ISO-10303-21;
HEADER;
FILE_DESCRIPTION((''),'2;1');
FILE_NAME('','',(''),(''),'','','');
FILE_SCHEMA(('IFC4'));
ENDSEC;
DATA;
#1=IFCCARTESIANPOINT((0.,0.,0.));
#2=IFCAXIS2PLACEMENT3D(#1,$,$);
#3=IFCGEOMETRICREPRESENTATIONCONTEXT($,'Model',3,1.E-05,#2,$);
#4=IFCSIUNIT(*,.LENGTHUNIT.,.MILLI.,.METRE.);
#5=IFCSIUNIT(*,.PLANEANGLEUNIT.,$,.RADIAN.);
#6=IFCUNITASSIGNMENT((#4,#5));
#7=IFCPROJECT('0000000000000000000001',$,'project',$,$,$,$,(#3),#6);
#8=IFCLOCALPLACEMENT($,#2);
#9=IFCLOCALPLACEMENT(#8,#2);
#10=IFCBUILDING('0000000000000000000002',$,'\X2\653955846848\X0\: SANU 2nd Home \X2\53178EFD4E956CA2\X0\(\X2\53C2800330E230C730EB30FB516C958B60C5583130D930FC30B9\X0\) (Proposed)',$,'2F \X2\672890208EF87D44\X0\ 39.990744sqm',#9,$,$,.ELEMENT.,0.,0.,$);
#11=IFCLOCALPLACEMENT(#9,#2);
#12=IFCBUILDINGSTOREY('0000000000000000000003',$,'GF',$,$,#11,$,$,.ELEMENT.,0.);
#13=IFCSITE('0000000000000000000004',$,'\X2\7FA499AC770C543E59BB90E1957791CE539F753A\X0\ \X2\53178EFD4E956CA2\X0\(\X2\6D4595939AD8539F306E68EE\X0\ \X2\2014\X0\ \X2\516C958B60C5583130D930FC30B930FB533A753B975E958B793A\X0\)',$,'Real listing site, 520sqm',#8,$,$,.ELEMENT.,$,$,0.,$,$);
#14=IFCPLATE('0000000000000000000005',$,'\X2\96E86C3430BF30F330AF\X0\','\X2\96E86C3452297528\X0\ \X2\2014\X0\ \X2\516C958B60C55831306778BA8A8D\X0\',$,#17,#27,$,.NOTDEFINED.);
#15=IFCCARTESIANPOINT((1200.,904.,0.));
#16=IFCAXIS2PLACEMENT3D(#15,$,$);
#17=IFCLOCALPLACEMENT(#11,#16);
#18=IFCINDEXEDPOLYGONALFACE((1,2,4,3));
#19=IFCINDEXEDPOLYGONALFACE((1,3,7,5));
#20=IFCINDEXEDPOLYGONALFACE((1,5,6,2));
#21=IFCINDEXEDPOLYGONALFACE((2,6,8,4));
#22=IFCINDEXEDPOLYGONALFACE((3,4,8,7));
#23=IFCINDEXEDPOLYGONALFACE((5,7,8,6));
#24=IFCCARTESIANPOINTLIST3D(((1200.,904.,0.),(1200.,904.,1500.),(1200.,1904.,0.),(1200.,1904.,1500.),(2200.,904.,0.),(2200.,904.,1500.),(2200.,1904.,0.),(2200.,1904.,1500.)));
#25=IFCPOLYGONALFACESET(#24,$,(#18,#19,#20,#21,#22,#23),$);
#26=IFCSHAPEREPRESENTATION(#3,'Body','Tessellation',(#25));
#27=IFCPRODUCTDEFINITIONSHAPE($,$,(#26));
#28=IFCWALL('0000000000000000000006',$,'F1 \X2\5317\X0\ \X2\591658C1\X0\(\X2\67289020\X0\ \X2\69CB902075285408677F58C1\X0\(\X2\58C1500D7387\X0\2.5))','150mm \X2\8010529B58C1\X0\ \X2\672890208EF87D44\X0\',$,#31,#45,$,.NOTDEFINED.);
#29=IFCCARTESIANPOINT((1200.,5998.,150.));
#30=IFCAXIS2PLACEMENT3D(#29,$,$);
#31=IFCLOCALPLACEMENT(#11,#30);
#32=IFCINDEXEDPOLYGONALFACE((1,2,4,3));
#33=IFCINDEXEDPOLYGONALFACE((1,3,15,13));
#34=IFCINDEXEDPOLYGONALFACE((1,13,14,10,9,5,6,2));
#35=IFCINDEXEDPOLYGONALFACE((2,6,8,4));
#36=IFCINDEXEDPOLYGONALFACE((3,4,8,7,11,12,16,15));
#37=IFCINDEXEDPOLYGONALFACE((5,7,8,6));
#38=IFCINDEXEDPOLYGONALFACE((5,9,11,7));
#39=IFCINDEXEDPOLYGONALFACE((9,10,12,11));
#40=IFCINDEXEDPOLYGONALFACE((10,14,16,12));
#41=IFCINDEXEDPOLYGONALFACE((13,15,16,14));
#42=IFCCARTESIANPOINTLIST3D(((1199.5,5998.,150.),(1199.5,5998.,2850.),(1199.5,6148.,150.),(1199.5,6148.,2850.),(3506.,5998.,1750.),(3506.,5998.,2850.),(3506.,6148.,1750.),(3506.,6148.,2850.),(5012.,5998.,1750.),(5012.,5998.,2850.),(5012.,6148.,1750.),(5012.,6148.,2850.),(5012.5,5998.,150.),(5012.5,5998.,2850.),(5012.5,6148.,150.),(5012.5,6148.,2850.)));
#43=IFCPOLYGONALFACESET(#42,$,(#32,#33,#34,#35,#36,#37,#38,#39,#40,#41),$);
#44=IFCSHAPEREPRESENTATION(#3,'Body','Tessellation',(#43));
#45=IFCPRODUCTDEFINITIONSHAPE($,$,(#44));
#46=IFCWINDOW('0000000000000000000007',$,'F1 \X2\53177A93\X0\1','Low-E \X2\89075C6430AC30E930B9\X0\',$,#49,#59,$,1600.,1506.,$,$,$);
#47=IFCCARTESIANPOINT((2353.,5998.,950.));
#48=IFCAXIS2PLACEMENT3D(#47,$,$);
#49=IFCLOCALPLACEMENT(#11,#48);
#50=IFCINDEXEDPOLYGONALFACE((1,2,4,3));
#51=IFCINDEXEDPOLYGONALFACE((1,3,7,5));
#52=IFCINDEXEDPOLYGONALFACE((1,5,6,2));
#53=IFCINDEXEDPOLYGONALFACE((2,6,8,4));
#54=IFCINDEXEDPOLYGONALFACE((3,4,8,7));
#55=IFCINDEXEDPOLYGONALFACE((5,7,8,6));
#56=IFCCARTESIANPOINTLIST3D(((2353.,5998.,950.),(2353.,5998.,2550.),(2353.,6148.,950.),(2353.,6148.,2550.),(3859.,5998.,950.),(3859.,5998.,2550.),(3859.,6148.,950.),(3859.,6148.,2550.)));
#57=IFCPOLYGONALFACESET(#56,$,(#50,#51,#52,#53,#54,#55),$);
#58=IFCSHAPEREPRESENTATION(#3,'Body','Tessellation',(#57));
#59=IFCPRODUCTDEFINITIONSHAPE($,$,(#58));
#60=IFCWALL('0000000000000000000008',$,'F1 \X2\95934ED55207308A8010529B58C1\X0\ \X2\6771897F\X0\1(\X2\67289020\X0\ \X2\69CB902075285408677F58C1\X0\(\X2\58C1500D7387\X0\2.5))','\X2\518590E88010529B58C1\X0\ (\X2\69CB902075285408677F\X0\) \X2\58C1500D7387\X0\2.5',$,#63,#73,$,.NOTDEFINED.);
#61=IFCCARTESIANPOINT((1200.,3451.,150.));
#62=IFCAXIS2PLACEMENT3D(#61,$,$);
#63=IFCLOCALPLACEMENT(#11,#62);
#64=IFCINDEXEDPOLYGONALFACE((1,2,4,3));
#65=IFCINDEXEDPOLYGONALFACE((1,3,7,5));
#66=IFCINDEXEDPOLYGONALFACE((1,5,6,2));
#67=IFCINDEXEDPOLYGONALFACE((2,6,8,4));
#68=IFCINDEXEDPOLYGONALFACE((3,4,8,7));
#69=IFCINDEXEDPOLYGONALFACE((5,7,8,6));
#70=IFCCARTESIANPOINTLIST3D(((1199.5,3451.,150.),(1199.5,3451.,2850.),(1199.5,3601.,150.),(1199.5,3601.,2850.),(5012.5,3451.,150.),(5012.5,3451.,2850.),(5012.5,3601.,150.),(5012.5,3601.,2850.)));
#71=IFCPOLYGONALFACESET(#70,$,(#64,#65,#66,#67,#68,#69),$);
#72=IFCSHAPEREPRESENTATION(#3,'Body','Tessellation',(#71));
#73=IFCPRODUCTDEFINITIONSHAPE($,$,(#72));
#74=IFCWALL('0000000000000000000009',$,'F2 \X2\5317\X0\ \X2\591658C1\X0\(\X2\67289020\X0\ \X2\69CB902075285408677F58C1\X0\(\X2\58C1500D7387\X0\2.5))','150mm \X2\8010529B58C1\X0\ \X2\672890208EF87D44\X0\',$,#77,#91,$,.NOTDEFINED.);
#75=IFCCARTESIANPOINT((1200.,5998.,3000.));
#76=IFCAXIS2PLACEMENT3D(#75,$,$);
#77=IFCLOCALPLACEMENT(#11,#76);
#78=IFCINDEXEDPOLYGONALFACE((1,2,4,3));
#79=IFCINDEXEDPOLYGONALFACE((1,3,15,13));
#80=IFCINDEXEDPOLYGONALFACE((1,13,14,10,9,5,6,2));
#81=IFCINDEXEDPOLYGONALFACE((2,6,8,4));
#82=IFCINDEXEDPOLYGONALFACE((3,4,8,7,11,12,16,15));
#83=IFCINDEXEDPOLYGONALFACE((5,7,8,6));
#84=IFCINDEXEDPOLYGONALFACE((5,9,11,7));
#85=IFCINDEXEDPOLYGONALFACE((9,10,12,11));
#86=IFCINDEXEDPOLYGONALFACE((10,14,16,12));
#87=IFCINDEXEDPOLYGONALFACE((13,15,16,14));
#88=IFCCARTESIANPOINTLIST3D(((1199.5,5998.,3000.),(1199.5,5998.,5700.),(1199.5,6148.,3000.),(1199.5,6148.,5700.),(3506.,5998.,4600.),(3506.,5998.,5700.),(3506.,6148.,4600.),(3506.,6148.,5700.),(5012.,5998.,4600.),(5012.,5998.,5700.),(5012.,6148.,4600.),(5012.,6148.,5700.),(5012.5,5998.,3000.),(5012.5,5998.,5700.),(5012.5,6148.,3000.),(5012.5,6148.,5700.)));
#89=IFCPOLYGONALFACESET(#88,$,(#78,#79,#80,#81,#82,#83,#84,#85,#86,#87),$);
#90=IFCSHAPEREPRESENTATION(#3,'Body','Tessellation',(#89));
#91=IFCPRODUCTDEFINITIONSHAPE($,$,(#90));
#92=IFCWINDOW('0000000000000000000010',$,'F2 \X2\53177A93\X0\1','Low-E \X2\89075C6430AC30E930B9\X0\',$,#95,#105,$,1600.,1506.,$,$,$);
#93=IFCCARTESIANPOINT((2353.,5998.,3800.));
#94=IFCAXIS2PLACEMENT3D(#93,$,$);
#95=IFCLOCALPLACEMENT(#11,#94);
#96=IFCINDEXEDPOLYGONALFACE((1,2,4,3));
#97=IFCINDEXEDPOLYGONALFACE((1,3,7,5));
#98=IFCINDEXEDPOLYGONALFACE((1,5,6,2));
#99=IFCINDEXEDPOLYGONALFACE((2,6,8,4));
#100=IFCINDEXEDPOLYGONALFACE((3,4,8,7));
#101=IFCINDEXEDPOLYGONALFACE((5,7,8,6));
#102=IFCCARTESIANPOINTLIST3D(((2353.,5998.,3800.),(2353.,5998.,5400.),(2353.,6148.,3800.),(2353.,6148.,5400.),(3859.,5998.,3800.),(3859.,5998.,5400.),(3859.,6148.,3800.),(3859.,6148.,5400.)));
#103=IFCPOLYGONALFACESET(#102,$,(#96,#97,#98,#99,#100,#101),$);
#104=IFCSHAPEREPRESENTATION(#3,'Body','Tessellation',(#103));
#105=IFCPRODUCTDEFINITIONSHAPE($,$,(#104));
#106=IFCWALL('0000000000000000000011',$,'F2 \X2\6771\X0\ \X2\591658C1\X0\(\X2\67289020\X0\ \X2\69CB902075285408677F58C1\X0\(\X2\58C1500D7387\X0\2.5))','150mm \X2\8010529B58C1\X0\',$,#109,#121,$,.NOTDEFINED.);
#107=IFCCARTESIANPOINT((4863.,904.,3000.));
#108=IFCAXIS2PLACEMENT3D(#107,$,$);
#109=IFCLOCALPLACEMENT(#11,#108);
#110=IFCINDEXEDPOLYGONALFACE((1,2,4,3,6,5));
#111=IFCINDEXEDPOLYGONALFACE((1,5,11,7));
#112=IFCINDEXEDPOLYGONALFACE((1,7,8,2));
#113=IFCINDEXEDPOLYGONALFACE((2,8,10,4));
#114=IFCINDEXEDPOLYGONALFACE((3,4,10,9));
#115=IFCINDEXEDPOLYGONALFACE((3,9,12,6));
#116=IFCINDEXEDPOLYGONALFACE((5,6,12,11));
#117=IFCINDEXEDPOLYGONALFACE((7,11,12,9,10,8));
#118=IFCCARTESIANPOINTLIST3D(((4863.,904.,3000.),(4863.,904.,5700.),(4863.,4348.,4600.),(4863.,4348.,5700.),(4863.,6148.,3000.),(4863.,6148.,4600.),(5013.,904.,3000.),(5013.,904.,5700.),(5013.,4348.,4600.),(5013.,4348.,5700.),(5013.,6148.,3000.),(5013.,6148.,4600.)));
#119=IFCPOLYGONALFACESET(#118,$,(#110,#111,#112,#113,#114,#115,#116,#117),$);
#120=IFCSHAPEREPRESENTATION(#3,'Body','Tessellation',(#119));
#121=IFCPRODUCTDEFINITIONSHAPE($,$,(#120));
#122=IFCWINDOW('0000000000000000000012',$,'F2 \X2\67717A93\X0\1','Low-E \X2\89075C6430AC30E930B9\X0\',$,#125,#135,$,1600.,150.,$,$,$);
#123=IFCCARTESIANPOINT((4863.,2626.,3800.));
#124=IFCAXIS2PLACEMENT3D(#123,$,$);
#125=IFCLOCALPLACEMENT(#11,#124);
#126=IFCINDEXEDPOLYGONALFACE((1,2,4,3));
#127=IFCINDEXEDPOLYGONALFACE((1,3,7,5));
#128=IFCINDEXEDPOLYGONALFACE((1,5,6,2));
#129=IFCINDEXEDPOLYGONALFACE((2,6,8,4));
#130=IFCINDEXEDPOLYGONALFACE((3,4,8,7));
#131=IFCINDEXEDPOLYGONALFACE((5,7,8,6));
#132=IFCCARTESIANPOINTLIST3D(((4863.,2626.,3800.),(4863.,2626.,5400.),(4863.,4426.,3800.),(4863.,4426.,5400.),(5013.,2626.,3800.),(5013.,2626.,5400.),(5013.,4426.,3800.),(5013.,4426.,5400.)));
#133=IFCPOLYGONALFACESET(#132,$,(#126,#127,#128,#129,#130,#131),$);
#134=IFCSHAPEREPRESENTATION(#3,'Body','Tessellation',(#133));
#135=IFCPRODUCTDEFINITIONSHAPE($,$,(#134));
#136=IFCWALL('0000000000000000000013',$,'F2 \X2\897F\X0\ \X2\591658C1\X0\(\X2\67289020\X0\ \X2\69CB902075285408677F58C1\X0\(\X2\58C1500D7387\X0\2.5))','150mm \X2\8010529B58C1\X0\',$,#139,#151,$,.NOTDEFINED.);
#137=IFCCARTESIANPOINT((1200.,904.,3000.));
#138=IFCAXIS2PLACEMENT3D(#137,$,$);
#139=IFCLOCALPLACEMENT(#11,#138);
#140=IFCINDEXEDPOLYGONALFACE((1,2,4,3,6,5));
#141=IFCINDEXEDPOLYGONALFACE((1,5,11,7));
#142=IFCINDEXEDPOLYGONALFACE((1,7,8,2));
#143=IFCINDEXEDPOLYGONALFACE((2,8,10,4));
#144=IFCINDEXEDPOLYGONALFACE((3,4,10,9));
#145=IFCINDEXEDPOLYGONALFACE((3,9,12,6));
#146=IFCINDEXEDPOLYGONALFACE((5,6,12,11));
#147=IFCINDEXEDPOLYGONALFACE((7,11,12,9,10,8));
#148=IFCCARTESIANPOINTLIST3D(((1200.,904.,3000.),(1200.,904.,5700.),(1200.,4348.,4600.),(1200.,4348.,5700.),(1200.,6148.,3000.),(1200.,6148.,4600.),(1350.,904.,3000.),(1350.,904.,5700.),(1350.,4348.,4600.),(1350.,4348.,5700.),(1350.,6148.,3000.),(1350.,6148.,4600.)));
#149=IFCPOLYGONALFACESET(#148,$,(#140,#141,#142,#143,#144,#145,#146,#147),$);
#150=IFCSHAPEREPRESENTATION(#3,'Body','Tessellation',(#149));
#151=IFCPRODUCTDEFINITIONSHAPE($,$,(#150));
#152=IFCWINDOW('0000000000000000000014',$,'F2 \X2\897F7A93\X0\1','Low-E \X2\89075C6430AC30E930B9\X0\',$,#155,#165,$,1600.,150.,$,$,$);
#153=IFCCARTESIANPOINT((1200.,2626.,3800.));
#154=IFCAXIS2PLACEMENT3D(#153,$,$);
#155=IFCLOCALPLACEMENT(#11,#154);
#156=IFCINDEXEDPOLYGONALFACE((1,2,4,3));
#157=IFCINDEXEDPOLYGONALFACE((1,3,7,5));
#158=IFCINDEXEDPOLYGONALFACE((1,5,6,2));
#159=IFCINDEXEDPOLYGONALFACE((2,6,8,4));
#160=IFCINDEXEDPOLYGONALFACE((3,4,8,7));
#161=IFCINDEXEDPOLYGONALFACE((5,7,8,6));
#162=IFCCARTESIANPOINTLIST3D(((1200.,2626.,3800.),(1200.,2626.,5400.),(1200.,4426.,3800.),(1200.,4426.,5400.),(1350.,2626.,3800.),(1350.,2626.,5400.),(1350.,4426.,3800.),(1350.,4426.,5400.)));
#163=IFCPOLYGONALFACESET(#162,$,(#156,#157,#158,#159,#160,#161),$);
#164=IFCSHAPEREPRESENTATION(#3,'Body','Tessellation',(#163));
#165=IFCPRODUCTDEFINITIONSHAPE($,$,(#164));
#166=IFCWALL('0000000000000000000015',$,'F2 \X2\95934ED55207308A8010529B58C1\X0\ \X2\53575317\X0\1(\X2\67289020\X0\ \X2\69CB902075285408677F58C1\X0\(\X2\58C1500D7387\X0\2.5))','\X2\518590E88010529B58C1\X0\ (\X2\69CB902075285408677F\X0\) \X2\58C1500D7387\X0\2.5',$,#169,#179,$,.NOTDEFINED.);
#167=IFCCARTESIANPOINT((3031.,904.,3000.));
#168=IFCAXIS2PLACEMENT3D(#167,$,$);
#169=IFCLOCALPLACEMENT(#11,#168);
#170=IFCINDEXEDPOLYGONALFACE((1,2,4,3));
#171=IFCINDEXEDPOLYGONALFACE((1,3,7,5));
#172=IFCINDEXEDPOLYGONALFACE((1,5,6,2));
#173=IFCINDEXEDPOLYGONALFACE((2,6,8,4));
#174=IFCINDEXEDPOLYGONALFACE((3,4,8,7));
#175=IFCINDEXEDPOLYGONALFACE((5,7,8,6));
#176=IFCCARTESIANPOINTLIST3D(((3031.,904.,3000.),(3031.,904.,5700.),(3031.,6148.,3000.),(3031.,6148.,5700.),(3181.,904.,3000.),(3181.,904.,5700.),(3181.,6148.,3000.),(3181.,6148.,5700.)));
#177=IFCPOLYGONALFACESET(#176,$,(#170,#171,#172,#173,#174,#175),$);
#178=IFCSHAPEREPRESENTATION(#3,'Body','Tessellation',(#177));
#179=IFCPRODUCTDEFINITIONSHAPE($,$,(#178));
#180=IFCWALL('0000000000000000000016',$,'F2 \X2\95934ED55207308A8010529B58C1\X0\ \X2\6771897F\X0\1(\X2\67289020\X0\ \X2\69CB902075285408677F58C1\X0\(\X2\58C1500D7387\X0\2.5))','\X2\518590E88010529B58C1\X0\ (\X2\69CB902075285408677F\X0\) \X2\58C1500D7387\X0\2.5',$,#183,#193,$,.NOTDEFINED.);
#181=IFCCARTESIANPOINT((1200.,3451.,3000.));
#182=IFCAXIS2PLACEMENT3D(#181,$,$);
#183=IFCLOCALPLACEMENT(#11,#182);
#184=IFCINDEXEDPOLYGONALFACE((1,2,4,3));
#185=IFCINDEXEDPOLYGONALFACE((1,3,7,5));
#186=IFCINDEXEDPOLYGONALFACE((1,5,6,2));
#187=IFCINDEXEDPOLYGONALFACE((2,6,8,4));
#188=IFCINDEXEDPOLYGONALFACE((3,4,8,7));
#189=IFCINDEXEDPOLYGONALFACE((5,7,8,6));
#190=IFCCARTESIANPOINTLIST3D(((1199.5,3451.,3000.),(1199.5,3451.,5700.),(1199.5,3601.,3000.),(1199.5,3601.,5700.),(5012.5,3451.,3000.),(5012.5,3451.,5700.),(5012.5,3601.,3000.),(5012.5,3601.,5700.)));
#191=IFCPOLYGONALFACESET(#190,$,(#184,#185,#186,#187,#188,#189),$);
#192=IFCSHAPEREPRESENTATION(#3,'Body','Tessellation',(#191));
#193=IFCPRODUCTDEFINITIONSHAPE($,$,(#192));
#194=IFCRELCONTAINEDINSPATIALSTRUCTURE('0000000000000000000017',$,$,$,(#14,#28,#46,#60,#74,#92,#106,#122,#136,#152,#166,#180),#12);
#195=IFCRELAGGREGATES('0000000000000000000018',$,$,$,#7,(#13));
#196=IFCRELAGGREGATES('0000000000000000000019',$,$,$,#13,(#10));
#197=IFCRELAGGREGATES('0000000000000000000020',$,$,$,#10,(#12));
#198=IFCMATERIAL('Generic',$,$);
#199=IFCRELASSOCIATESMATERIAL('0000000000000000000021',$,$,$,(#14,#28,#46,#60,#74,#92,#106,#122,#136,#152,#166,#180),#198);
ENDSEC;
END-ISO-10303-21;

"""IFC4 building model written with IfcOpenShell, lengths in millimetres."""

from ifc_helpers import new_model, si_unit, frame, frame_2d, origin, place, context, project, spatial, rectangle, extrude, material, element, fill, save


model = new_model("IFC4")

# Units and contexts
model_context = context("Model", 3, precision=1e-05, world=origin())
ifc_project = project(units=[si_unit("LENGTHUNIT", "METRE", prefix="MILLI"), si_unit("PLANEANGLEUNIT", "RADIAN")], contexts=[model_context])

# Site, building, storey
site_placement = place(None, origin())
site = spatial("IfcSite", under=ifc_project, at=site_placement, Name="群馬県吾妻郡長野原町 北軽井沢(浅間高原の森 — 公開情報ベース・区画非開示)", ObjectType="Real listing site, 520sqm", CompositionType="ELEMENT", RefElevation=0.0)
building_placement = place(site_placement, origin())
building = spatial("IfcBuilding", under=site, at=building_placement, Name="改善案: SANU 2nd Home 北軽井沢(参考モデル・公開情報ベース) (Proposed)", ObjectType="2F 木造軸組 39.990744sqm", CompositionType="ELEMENT", ElevationOfRefHeight=0.0, ElevationOfTerrain=0.0)
storey_placement = place(building_placement, origin())
storey = spatial("IfcBuildingStorey", under=building, at=storey_placement, Name="GF", CompositionType="ELEMENT", Elevation=0.0)

# Plate
ifc_material_1 = material(Name="Generic")
plate_placement = place(storey_placement, frame((1200.0, 904.0, 0.0)))
element("IfcPlate", 1, at=plate_placement, inside=storey, material=ifc_material_1, Name="雨水タンク", Description="雨水利用 — 公開情報で確認", PredefinedType="NOTDEFINED", context=model_context, shape_type="SweptSolid", body=[
    extrude(rectangle(XDim=1000.0, YDim=1000.0, at=frame_2d((500.0, 500.0))), frame((1200.0, 904.0, 0.0)), (0.0, 0.0, 1.0), 1500.0),
])

# Wall, opening, window
wall_1_placement = place(storey_placement, frame((1200.0, 5998.0, 150.0)))
wall_1 = element("IfcWall", 2, at=wall_1_placement, inside=storey, material=ifc_material_1, Name="F1 北 外壁(木造 構造用合板壁(壁倍率2.5))", Description="150mm 耐力壁 木造軸組", PredefinedType="NOTDEFINED", context=model_context, shape_type="SweptSolid", body=[
    extrude(rectangle(XDim=3813.0, YDim=150.0, at=frame_2d((1906.0, 75.0))), frame((1200.0, 5998.0, 150.0)), (0.0, 0.0, 1.0), 2700.0),
])
opening_1_placement = place(storey_placement, frame((2353.0, 5998.0, 950.0)))
opening_1 = element("IfcOpeningElement", 3, at=opening_1_placement, cuts=wall_1, PredefinedType="NOTDEFINED", context=model_context, shape_type="SweptSolid", body=[
    extrude(rectangle(XDim=1506.0, YDim=150.0, at=frame_2d((753.0, 75.0))), frame((2353.0, 5998.0, 950.0)), (0.0, 0.0, 1.0), 1600.0),
])
window_1_placement = place(storey_placement, frame((2353.0, 5998.0, 950.0)))
window_1 = element("IfcWindow", 4, at=window_1_placement, inside=storey, material=ifc_material_1, Name="F1 北窓1", Description="Low-E 複層ガラス", OverallHeight=1600.0, OverallWidth=1506.0, context=model_context, shape_type="SweptSolid", body=[
    extrude(rectangle(XDim=1506.0, YDim=150.0, at=frame_2d((753.0, 75.0))), frame((2353.0, 5998.0, 950.0)), (0.0, 0.0, 1.0), 1600.0),
])
fill(opening_1, window_1)

# Wall
wall_2_placement = place(storey_placement, frame((1200.0, 3451.0, 150.0)))
element("IfcWall", 5, at=wall_2_placement, inside=storey, material=ifc_material_1, Name="F1 間仕切り耐力壁 東西1(木造 構造用合板壁(壁倍率2.5))", Description="内部耐力壁 (構造用合板) 壁倍率2.5", PredefinedType="NOTDEFINED", context=model_context, shape_type="SweptSolid", body=[
    extrude(rectangle(XDim=3813.0, YDim=150.0, at=frame_2d((1906.0, 75.0))), frame((1200.0, 3451.0, 150.0)), (0.0, 0.0, 1.0), 2700.0),
])

# Walls, openings, windows
wall_3_placement = place(storey_placement, frame((1200.0, 5998.0, 3000.0)))
wall_3 = element("IfcWall", 6, at=wall_3_placement, inside=storey, material=ifc_material_1, Name="F2 北 外壁(木造 構造用合板壁(壁倍率2.5))", Description="150mm 耐力壁 木造軸組", PredefinedType="NOTDEFINED", context=model_context, shape_type="SweptSolid", body=[
    extrude(rectangle(XDim=3813.0, YDim=150.0, at=frame_2d((1906.0, 75.0))), frame((1200.0, 5998.0, 3000.0)), (0.0, 0.0, 1.0), 2700.0),
])
opening_2_placement = place(storey_placement, frame((2353.0, 5998.0, 3800.0)))
opening_2 = element("IfcOpeningElement", 7, at=opening_2_placement, cuts=wall_3, PredefinedType="NOTDEFINED", context=model_context, shape_type="SweptSolid", body=[
    extrude(rectangle(XDim=1506.0, YDim=150.0, at=frame_2d((753.0, 75.0))), frame((2353.0, 5998.0, 3800.0)), (0.0, 0.0, 1.0), 1600.0),
])
window_2_placement = place(storey_placement, frame((2353.0, 5998.0, 3800.0)))
window_2 = element("IfcWindow", 8, at=window_2_placement, inside=storey, material=ifc_material_1, Name="F2 北窓1", Description="Low-E 複層ガラス", OverallHeight=1600.0, OverallWidth=1506.0, context=model_context, shape_type="SweptSolid", body=[
    extrude(rectangle(XDim=1506.0, YDim=150.0, at=frame_2d((753.0, 75.0))), frame((2353.0, 5998.0, 3800.0)), (0.0, 0.0, 1.0), 1600.0),
])
fill(opening_2, window_2)
wall_4_placement = place(storey_placement, frame((4863.0, 904.0, 3000.0)))
wall_4 = element("IfcWall", 9, at=wall_4_placement, inside=storey, material=ifc_material_1, Name="F2 東 外壁(木造 構造用合板壁(壁倍率2.5))", Description="150mm 耐力壁", PredefinedType="NOTDEFINED", context=model_context, shape_type="SweptSolid", body=[
    extrude(rectangle(XDim=150.0, YDim=5244.0, at=frame_2d((75.0, 2622.0))), frame((4863.0, 904.0, 3000.0)), (0.0, 0.0, 1.0), 2700.0),
])
opening_3_placement = place(storey_placement, frame((4863.0, 2626.0, 3800.0)))
opening_3 = element("IfcOpeningElement", 10, at=opening_3_placement, cuts=wall_4, PredefinedType="NOTDEFINED", context=model_context, shape_type="SweptSolid", body=[
    extrude(rectangle(XDim=150.0, YDim=1800.0, at=frame_2d((75.0, 900.0))), frame((4863.0, 2626.0, 3800.0)), (0.0, 0.0, 1.0), 1600.0),
])
window_3_placement = place(storey_placement, frame((4863.0, 2626.0, 3800.0)))
window_3 = element("IfcWindow", 11, at=window_3_placement, inside=storey, material=ifc_material_1, Name="F2 東窓1", Description="Low-E 複層ガラス", OverallHeight=1600.0, OverallWidth=150.0, context=model_context, shape_type="SweptSolid", body=[
    extrude(rectangle(XDim=150.0, YDim=1800.0, at=frame_2d((75.0, 900.0))), frame((4863.0, 2626.0, 3800.0)), (0.0, 0.0, 1.0), 1600.0),
])
fill(opening_3, window_3)
wall_5_placement = place(storey_placement, frame((1200.0, 904.0, 3000.0)))
wall_5 = element("IfcWall", 12, at=wall_5_placement, inside=storey, material=ifc_material_1, Name="F2 西 外壁(木造 構造用合板壁(壁倍率2.5))", Description="150mm 耐力壁", PredefinedType="NOTDEFINED", context=model_context, shape_type="SweptSolid", body=[
    extrude(rectangle(XDim=150.0, YDim=5244.0, at=frame_2d((75.0, 2622.0))), frame((1200.0, 904.0, 3000.0)), (0.0, 0.0, 1.0), 2700.0),
])
opening_4_placement = place(storey_placement, frame((1200.0, 2626.0, 3800.0)))
opening_4 = element("IfcOpeningElement", 13, at=opening_4_placement, cuts=wall_5, PredefinedType="NOTDEFINED", context=model_context, shape_type="SweptSolid", body=[
    extrude(rectangle(XDim=150.0, YDim=1800.0, at=frame_2d((75.0, 900.0))), frame((1200.0, 2626.0, 3800.0)), (0.0, 0.0, 1.0), 1600.0),
])
window_4_placement = place(storey_placement, frame((1200.0, 2626.0, 3800.0)))
window_4 = element("IfcWindow", 14, at=window_4_placement, inside=storey, material=ifc_material_1, Name="F2 西窓1", Description="Low-E 複層ガラス", OverallHeight=1600.0, OverallWidth=150.0, context=model_context, shape_type="SweptSolid", body=[
    extrude(rectangle(XDim=150.0, YDim=1800.0, at=frame_2d((75.0, 900.0))), frame((1200.0, 2626.0, 3800.0)), (0.0, 0.0, 1.0), 1600.0),
])
fill(opening_4, window_4)

# Walls
wall_6_placement = place(storey_placement, frame((3031.0, 904.0, 3000.0)))
element("IfcWall", 15, at=wall_6_placement, inside=storey, material=ifc_material_1, Name="F2 間仕切り耐力壁 南北1(木造 構造用合板壁(壁倍率2.5))", Description="内部耐力壁 (構造用合板) 壁倍率2.5", PredefinedType="NOTDEFINED", context=model_context, shape_type="SweptSolid", body=[
    extrude(rectangle(XDim=150.0, YDim=5244.0, at=frame_2d((75.0, 2622.0))), frame((3031.0, 904.0, 3000.0)), (0.0, 0.0, 1.0), 2700.0),
])
wall_7_placement = place(storey_placement, frame((1200.0, 3451.0, 3000.0)))
element("IfcWall", 16, at=wall_7_placement, inside=storey, material=ifc_material_1, Name="F2 間仕切り耐力壁 東西1(木造 構造用合板壁(壁倍率2.5))", Description="内部耐力壁 (構造用合板) 壁倍率2.5", PredefinedType="NOTDEFINED", context=model_context, shape_type="SweptSolid", body=[
    extrude(rectangle(XDim=3813.0, YDim=150.0, at=frame_2d((1906.0, 75.0))), frame((1200.0, 3451.0, 3000.0)), (0.0, 0.0, 1.0), 2700.0),
])

save(model, "model.ifc")
